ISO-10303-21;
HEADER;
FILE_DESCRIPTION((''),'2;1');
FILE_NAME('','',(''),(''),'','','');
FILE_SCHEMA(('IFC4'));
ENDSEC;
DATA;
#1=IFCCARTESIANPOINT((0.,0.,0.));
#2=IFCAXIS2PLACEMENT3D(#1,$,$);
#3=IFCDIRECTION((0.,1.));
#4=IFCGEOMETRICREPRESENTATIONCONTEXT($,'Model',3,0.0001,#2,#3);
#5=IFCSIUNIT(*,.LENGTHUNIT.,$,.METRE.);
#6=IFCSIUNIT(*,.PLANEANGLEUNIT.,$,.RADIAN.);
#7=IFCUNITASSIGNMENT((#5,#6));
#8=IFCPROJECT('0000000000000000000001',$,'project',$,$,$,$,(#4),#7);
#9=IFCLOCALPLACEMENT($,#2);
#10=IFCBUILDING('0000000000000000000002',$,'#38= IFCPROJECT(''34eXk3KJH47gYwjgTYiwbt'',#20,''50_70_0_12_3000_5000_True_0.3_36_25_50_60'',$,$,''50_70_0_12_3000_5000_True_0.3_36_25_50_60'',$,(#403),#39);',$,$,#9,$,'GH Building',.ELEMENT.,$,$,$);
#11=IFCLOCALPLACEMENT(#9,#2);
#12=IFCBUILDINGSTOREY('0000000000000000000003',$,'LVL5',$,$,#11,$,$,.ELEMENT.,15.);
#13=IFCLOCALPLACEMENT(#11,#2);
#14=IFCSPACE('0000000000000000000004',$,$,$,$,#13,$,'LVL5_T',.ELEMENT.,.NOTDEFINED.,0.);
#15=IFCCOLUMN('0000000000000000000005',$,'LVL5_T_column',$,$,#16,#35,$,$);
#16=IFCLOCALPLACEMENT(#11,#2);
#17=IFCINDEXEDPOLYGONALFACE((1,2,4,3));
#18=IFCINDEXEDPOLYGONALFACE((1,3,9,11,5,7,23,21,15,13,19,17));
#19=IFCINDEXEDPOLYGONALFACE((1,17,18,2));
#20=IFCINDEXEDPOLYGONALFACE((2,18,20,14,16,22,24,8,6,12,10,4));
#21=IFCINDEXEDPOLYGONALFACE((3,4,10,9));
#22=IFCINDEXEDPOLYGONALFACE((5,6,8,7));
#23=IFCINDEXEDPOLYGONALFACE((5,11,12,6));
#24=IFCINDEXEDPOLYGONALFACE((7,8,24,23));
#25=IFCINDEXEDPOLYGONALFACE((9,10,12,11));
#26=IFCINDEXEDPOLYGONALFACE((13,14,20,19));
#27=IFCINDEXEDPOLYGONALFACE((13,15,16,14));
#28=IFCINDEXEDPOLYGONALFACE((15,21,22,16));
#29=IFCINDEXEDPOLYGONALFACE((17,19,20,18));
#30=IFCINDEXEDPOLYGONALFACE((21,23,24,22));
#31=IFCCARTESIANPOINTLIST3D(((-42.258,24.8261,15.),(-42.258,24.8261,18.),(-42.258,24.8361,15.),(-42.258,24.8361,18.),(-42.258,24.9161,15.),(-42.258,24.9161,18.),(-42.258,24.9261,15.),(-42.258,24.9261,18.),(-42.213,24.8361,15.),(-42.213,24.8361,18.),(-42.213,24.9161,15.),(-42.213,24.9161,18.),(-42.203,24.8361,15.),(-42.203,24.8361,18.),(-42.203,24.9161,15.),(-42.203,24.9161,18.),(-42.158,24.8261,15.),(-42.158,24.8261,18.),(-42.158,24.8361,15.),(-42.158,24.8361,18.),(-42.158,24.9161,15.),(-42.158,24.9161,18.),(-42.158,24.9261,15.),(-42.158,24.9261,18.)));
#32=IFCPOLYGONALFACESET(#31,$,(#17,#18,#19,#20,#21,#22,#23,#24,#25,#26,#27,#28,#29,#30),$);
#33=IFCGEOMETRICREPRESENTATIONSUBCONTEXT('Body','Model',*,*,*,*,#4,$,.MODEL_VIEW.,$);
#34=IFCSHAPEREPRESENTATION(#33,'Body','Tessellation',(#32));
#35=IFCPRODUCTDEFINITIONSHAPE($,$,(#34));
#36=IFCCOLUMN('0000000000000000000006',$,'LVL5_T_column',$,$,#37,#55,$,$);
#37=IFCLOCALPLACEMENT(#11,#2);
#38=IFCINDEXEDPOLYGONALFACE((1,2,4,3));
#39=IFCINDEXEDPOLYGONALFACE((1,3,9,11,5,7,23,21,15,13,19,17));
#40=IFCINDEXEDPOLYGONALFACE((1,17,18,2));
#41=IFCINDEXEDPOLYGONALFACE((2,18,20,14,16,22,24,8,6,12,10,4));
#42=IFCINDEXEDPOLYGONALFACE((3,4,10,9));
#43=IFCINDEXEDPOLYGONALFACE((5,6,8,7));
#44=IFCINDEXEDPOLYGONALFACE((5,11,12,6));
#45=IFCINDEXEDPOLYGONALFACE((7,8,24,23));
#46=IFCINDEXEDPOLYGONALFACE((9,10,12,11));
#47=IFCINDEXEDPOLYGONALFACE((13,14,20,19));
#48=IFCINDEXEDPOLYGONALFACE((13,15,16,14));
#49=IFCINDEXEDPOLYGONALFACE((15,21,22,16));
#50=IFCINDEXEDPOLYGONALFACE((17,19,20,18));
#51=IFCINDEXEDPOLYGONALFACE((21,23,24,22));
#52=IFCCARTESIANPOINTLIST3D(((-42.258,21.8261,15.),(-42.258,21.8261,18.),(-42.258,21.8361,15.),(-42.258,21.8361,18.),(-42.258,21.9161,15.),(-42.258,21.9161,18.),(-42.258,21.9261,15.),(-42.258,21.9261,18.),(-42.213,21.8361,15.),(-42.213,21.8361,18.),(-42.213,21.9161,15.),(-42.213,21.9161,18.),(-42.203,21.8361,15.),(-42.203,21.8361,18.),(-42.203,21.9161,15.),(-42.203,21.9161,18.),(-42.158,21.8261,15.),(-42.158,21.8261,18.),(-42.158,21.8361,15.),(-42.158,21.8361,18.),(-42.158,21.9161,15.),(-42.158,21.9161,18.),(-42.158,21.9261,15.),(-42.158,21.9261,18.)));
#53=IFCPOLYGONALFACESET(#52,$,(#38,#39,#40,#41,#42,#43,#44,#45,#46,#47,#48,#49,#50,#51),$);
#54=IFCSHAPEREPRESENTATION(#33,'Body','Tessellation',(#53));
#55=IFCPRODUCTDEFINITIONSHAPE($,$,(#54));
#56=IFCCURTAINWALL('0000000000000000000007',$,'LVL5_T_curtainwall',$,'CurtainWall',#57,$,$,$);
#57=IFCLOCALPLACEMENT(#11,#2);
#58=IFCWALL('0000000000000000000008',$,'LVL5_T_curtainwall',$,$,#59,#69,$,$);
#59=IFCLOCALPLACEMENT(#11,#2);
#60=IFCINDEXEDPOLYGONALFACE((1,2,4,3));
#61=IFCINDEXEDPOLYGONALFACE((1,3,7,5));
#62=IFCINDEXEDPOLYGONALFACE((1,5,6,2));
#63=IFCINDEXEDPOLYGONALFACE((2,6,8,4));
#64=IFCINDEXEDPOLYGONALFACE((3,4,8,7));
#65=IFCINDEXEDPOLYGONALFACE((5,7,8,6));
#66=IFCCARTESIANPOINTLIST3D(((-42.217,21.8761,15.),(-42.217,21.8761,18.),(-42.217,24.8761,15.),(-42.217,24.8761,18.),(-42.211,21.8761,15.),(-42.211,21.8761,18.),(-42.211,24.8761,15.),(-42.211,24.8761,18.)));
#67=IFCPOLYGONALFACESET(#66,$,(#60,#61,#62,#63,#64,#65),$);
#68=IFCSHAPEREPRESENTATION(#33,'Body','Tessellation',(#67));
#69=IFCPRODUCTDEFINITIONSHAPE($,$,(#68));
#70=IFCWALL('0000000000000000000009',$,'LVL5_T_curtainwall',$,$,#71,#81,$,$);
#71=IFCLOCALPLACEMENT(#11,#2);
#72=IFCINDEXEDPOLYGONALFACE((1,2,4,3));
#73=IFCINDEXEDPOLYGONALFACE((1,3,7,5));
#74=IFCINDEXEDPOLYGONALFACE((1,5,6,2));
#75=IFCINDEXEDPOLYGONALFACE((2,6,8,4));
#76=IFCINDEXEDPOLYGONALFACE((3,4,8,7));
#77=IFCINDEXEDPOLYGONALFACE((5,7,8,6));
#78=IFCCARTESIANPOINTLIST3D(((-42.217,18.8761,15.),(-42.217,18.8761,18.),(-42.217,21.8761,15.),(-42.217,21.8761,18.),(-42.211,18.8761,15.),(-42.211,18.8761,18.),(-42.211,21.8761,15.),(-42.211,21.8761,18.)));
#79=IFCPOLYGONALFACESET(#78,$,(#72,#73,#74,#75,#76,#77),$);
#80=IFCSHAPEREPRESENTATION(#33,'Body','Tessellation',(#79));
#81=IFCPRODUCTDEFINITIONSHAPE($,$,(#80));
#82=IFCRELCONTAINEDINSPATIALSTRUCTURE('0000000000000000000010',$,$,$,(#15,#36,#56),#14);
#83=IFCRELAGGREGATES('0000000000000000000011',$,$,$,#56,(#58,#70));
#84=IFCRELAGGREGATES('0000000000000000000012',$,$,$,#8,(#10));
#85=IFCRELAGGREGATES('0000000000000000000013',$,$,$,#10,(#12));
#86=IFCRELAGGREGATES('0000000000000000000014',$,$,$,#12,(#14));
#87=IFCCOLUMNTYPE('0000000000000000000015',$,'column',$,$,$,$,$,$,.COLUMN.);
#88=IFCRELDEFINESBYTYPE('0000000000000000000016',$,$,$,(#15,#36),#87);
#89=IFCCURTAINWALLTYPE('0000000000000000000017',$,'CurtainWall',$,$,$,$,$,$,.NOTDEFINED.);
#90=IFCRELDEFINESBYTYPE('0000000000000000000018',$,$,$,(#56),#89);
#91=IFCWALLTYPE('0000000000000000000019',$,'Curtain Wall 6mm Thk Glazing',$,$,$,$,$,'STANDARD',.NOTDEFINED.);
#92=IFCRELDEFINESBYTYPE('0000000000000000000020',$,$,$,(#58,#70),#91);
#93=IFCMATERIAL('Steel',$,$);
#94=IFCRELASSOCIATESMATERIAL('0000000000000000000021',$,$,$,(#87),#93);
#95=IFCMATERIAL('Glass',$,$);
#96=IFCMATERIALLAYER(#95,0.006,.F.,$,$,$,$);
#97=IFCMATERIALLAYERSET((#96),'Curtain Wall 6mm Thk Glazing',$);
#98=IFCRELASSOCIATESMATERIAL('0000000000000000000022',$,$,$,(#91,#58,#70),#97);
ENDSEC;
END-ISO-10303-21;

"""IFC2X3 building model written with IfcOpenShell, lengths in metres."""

from ifc_helpers import new_model, si_unit, direction, frame, frame_2d, origin, origin_2d, place, context, subcontext, project, spatial, rectangle, i_section, extrude, material, layer, layer_set, layer_usage, type_object, element, aggregate, save


model = new_model("IFC2X3")

# Units and contexts
model_context = context("Model", 3, precision=0.0001, world=origin(), true_north=direction((0.0, 1.0)))
body_context = subcontext(model_context, "Body", "Model", "MODEL_VIEW")
ifc_project = project(units=[si_unit("LENGTHUNIT", "METRE"), si_unit("PLANEANGLEUNIT", "RADIAN")], contexts=[model_context])

# Building, storey, space
building_placement = place(None, origin())
building = spatial("IfcBuilding", under=ifc_project, at=building_placement, Name="#38= IFCPROJECT('34eXk3KJH47gYwjgTYiwbt',#20,'50_70_0_12_3000_5000_True_0.3_36_25_50_60',$,$,'50_70_0_12_3000_5000_True_0.3_36_25_50_60',$,(#403),#39);", LongName="GH Building", CompositionType="ELEMENT")
storey_placement = place(building_placement, origin())
storey = spatial("IfcBuildingStorey", under=building, at=storey_placement, Name="LVL5", CompositionType="ELEMENT", Elevation=15.0)
space_1_placement = place(storey_placement, origin())
space_1 = spatial("IfcSpace", under=storey, at=space_1_placement, LongName="LVL5_T", CompositionType="ELEMENT", InteriorOrExteriorSpace="NOTDEFINED", ElevationWithFlooring=0.0)

# Columns
ifc_material_1 = material(Name="Steel")
column_type = type_object("IfcColumnType", Name="column", PredefinedType="COLUMN", material=ifc_material_1)
for number, where, name in (
    (1, (-42.208, 24.8761, 15.0), "LVL5_T_column"),
    (2, (-42.208, 21.8761, 15.0), "LVL5_T_column"),
):
    element("IfcColumn", number, at=place(space_1_placement, frame(where)), inside=space_1, type_object=column_type, Name=name, context=body_context, shape_type="SweptSolid", body=[
        extrude(i_section(OverallWidth=0.1, OverallDepth=0.1, WebThickness=0.01, FlangeThickness=0.01, at=origin_2d()), origin(), (0.0, 0.0, 1.0), 3.0),
    ])

# Curtain wall, walls
curtain_wall_type = type_object("IfcCurtainWallType", Name="CurtainWall", PredefinedType="NOTDEFINED")
curtain_wall_1_placement = place(None, origin())
curtain_wall_1 = element("IfcCurtainWall", 3, at=curtain_wall_1_placement, inside=space_1, type_object=curtain_wall_type, Name="LVL5_T_curtainwall", ObjectType="CurtainWall")
ifc_material_2 = material(Name="Glass")
ifc_layer = layer(ifc_material_2, 0.006, ventilated=False)
ifc_layer_set = layer_set([ifc_layer], Name="Curtain Wall 6mm Thk Glazing")
ifc_layer_usage_1 = layer_usage(ifc_layer_set, "AXIS2", "NEGATIVE", -0.003)
wall_type = type_object("IfcWallType", Name="Curtain Wall 6mm Thk Glazing", ElementType="STANDARD", PredefinedType="NOTDEFINED", material=ifc_layer_set)
wall_1_placement = place(curtain_wall_1_placement, frame((-42.208, 24.8761, 15.0), z_axis=(0.0, 0.0, 1.0), x_axis=(0.0, -1.0, 0.0)))
wall_1 = element("IfcWall", 4, at=wall_1_placement, type_object=wall_type, material=ifc_layer_usage_1, Name="LVL5_T_curtainwall", context=body_context, shape_type="SweptSolid", body=[
    extrude(rectangle(XDim=3.0, YDim=0.006, at=frame_2d((1.5, -0.006))), origin(), (0.0, 0.0, 1.0), 3.0),
])
ifc_layer_usage_2 = layer_usage(ifc_layer_set, "AXIS2", "NEGATIVE", -0.003)
wall_2_placement = place(curtain_wall_1_placement, frame((-42.208, 21.8761, 15.0), z_axis=(0.0, 0.0, 1.0), x_axis=(0.0, -1.0, 0.0)))
wall_2 = element("IfcWall", 5, at=wall_2_placement, type_object=wall_type, material=ifc_layer_usage_2, Name="LVL5_T_curtainwall", context=body_context, shape_type="SweptSolid", body=[
    extrude(rectangle(XDim=3.0, YDim=0.006, at=frame_2d((1.5, -0.006))), origin(), (0.0, 0.0, 1.0), 3.0),
])
aggregate(curtain_wall_1, [wall_1, wall_2])

save(model, "model.ifc")
